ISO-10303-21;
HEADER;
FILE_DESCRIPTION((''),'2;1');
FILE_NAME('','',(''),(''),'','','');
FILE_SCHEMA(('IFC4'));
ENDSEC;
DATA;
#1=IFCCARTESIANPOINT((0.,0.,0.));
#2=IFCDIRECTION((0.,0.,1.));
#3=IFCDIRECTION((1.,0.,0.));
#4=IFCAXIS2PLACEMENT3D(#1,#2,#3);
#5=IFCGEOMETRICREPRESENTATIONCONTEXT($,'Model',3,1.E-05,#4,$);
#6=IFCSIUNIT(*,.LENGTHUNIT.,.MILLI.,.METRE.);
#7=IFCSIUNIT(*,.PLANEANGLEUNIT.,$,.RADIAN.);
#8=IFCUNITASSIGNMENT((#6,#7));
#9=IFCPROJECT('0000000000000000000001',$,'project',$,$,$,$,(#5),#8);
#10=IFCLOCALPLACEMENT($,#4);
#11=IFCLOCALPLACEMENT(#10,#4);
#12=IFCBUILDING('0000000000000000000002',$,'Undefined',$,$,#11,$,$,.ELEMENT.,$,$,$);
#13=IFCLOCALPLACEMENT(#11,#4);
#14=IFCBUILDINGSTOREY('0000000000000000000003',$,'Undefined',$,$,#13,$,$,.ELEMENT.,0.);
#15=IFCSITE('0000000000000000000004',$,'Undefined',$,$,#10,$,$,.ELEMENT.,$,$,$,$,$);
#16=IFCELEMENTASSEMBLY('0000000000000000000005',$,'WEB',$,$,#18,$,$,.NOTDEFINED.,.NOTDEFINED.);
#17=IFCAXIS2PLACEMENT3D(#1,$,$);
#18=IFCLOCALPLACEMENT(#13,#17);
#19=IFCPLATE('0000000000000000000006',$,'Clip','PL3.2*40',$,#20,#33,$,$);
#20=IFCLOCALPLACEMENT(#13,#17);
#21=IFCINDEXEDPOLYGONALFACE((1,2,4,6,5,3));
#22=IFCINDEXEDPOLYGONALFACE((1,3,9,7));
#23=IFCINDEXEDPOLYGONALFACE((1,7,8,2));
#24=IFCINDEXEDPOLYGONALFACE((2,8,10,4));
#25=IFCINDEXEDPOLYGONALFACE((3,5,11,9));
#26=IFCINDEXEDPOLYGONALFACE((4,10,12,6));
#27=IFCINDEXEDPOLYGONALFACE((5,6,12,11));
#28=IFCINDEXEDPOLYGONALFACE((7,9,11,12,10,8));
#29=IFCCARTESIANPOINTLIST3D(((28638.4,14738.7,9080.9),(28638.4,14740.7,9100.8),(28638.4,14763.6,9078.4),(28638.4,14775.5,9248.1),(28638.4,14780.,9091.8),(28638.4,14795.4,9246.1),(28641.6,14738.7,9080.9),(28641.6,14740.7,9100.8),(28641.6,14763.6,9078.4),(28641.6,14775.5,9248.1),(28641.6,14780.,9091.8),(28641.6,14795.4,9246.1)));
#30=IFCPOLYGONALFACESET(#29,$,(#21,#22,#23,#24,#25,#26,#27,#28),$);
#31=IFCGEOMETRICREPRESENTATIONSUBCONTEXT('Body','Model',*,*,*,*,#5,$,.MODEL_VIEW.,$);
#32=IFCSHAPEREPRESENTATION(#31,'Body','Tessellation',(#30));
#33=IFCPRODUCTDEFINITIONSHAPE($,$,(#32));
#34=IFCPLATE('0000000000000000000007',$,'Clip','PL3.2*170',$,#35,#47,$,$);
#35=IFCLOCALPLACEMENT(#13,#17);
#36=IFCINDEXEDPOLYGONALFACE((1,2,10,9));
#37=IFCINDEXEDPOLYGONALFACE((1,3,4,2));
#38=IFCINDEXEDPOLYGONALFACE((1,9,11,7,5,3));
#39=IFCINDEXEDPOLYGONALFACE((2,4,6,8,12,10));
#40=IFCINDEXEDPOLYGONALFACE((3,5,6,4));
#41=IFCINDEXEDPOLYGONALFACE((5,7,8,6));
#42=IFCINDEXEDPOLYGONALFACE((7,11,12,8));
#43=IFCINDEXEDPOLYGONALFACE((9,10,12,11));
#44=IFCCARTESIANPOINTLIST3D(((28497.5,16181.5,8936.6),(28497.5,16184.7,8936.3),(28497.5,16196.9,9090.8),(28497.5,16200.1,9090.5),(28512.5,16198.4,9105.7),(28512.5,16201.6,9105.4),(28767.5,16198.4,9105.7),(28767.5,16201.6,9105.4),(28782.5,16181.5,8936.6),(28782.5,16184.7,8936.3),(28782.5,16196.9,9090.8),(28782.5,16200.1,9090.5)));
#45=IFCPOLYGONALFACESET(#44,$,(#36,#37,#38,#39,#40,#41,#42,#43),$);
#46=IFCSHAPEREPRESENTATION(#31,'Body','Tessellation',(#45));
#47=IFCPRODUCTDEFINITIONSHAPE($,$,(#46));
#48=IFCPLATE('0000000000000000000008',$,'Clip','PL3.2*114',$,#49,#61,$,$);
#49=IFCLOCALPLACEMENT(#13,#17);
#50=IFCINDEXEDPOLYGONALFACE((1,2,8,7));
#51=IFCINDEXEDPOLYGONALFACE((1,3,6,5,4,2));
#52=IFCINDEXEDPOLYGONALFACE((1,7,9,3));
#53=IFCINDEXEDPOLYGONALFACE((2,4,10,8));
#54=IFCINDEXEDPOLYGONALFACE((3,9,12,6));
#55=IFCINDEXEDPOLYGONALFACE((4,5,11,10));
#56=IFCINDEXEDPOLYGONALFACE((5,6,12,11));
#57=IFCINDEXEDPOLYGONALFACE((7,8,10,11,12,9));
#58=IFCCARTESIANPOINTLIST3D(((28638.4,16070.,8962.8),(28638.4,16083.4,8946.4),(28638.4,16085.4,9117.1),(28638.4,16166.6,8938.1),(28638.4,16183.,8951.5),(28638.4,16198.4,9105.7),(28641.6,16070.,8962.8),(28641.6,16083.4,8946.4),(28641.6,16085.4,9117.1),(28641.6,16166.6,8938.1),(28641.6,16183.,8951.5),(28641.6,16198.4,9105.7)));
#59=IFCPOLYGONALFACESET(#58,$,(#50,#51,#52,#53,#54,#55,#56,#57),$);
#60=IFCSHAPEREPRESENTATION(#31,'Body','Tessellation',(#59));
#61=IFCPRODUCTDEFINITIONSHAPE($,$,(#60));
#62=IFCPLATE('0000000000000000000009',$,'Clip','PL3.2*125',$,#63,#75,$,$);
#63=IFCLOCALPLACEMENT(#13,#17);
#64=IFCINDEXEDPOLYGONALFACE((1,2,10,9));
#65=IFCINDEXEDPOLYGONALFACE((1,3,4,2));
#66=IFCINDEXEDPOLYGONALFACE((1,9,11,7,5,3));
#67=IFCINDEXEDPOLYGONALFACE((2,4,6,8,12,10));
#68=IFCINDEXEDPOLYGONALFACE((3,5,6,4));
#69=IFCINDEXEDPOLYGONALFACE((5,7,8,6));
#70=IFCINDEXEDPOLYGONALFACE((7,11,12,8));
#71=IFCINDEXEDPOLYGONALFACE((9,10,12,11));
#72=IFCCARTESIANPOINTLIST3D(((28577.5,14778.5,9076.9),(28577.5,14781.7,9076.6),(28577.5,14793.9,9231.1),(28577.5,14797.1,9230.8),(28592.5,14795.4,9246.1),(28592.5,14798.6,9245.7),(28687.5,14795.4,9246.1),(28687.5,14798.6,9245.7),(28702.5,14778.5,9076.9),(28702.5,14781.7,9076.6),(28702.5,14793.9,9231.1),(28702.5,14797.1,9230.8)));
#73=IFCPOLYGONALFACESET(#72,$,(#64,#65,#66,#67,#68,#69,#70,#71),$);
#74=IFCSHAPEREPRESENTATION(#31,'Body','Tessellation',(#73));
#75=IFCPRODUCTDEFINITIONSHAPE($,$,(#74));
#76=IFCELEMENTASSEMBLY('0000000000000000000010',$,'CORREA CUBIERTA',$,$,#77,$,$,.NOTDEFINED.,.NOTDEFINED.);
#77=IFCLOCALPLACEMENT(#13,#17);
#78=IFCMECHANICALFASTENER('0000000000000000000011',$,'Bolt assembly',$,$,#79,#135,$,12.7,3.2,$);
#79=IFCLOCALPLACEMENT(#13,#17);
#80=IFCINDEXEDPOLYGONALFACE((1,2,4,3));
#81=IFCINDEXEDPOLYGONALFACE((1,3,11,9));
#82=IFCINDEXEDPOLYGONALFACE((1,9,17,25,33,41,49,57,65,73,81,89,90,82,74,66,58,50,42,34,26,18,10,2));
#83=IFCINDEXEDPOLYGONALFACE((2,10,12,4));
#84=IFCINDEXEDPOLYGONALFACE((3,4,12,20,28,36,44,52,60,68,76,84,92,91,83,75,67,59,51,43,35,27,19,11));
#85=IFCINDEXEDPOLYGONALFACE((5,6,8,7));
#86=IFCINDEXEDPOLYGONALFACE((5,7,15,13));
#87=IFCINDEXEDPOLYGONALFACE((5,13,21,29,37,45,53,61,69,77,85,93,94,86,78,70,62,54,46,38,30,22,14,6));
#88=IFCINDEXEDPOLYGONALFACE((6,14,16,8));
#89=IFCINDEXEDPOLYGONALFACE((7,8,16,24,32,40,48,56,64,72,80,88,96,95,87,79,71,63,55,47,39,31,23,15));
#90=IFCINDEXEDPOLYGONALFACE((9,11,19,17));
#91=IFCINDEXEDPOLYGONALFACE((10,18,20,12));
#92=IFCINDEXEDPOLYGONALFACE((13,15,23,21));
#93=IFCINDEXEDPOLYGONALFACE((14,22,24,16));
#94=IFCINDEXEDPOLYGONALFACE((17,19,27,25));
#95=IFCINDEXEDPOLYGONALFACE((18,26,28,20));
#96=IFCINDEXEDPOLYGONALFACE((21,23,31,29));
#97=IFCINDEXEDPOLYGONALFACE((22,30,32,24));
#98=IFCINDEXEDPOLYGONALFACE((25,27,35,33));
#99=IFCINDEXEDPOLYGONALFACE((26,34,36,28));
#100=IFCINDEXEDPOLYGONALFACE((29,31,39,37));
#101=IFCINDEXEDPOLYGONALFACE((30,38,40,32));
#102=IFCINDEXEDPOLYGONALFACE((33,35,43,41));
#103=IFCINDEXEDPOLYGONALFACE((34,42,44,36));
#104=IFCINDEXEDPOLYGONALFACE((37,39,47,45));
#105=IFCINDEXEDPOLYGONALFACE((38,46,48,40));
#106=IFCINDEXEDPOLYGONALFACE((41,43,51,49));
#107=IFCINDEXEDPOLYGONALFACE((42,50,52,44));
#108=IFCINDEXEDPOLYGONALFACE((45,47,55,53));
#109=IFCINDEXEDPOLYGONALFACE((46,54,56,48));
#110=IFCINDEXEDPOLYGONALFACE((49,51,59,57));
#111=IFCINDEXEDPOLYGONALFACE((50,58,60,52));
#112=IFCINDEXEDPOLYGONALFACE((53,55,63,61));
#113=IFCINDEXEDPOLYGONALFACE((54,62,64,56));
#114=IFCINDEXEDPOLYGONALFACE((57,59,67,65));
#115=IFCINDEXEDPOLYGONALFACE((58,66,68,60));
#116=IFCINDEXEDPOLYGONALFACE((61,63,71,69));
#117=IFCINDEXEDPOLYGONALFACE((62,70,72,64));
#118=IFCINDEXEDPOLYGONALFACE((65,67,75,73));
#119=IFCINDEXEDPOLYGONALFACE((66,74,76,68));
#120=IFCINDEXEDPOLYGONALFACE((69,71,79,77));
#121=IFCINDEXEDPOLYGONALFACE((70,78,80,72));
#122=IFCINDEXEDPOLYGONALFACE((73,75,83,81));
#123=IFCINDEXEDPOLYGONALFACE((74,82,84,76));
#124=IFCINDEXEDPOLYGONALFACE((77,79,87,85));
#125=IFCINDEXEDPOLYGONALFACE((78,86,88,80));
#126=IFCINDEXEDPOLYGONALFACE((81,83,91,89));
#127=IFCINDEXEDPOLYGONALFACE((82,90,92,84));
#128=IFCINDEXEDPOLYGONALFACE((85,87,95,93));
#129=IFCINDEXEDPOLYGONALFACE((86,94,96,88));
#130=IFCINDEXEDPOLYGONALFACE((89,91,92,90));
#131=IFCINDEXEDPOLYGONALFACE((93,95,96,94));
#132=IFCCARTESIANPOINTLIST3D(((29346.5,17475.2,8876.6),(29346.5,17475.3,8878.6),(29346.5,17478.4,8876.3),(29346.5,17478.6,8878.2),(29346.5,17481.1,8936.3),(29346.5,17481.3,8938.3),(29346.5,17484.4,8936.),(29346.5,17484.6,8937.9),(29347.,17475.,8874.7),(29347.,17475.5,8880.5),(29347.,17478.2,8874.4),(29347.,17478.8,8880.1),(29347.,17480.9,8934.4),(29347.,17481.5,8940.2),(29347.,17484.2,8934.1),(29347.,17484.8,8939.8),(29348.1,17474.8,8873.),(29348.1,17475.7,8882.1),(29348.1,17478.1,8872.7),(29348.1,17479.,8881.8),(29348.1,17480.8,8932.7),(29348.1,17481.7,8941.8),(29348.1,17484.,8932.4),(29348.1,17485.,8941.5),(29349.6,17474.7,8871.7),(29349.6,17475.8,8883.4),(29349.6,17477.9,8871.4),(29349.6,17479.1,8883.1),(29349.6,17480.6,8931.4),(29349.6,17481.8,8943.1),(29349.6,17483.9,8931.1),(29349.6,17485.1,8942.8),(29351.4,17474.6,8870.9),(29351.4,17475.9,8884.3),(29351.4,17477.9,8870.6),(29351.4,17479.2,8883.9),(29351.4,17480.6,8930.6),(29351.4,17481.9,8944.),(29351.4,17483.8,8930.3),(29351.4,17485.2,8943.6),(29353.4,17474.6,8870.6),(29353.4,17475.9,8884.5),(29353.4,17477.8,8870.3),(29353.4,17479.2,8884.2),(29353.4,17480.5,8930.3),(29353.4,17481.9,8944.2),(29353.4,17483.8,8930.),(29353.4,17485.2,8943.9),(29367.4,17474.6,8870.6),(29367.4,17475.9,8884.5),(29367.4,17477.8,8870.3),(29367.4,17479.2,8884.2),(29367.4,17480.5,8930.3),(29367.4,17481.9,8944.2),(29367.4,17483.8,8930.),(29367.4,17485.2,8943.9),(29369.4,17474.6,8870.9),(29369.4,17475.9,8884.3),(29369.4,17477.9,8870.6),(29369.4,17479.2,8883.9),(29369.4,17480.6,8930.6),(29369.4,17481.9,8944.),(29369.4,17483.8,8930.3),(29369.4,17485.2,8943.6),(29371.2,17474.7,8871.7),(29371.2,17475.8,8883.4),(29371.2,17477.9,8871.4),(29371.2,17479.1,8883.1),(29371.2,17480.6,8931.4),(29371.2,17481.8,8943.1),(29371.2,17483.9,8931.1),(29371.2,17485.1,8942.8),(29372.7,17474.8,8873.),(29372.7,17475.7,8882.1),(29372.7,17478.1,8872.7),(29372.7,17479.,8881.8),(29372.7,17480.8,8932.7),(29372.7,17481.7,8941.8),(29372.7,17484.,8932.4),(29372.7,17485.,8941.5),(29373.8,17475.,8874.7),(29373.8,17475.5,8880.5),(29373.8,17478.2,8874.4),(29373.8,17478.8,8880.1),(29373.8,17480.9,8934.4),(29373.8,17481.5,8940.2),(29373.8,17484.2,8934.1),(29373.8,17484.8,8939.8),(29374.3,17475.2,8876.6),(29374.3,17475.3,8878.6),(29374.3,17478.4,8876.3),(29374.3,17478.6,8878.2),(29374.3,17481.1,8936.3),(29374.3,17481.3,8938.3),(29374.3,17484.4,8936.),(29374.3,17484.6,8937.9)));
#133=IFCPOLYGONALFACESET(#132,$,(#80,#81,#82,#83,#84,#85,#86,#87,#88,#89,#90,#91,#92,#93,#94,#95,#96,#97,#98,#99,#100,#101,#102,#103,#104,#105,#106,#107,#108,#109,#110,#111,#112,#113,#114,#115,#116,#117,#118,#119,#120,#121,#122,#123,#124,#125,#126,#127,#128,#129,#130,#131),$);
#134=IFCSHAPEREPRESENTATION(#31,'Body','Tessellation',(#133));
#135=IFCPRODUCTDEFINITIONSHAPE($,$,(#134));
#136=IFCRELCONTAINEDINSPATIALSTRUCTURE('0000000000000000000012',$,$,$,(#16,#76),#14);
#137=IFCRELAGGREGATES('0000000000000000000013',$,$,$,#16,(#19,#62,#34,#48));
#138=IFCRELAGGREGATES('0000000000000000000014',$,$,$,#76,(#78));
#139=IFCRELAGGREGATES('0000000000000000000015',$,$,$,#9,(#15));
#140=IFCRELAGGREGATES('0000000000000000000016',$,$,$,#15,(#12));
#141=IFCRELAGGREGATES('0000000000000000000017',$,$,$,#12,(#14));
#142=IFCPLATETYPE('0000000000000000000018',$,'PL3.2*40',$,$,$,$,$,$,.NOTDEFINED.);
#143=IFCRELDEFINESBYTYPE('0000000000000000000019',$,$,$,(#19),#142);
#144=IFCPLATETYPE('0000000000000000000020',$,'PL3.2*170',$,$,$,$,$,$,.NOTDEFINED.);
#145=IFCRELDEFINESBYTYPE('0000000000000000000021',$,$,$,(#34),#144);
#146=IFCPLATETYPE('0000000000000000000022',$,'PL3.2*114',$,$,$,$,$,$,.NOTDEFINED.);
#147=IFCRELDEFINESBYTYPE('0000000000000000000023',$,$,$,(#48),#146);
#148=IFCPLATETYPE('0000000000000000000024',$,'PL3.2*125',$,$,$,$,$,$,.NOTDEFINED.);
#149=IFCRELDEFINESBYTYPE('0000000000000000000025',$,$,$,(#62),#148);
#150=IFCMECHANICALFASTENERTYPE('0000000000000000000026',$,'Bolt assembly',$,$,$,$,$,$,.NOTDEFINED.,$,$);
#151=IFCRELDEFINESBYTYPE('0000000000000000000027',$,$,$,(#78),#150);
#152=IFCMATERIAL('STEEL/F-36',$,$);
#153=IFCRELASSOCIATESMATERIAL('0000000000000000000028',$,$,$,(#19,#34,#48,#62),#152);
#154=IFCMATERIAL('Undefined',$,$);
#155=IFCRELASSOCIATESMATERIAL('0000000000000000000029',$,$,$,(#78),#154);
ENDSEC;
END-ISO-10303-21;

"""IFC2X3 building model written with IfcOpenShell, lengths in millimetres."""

from ifc_helpers import new_model, si_unit, frame, frame_2d, origin_with_axes, place, context, subcontext, project, spatial, polyline, circle_curve, parameter, trimmed, segment, composite_curve, outline, extrude, source, transform, mapped, material, type_object, element, aggregate, save


model = new_model("IFC2X3")

# Units and contexts
model_context = context("Model", 3, precision=1e-05, world=origin_with_axes())
body_context = subcontext(model_context, "Body", "Model", "MODEL_VIEW")
ifc_project = project(units=[si_unit("LENGTHUNIT", "METRE", prefix="MILLI"), si_unit("PLANEANGLEUNIT", "RADIAN")], contexts=[model_context])

# Site, building, storey
site_placement = place(None, origin_with_axes())
site = spatial("IfcSite", under=ifc_project, at=site_placement, Name="Undefined", CompositionType="ELEMENT")
building_placement = place(site_placement, origin_with_axes())
building = spatial("IfcBuilding", under=site, at=building_placement, Name="Undefined", CompositionType="ELEMENT")
storey_placement = place(building_placement, origin_with_axes())
storey = spatial("IfcBuildingStorey", under=building, at=storey_placement, Name="Undefined", CompositionType="ELEMENT", Elevation=0.0)

# Element assembly, plates
assembly_1_placement = place(storey_placement, origin_with_axes())
assembly_1 = element("IfcElementAssembly", 1, at=assembly_1_placement, inside=storey, Name="WEB", AssemblyPlace="NOTDEFINED", PredefinedType="NOTDEFINED")
ifc_material_1 = material(Name="STEEL/F-36")
plate_type_1 = type_object("IfcPlateType", Name="PL3.2*40", PredefinedType="NOTDEFINED")
plate_1_placement = place(assembly_1_placement, frame((28640.0, 14738.7, 9080.9), z_axis=(1.0, 0.0, 0.0), x_axis=(0.0, 0.995037, -0.099504)))
plate_1 = element("IfcPlate", 2, at=plate_1_placement, type_object=plate_type_1, material=ifc_material_1, Name="Clip", Description="PL3.2*40", context=body_context, shape_type="SweptSolid", body=[
    extrude(outline(polyline([(0.0, 0.0), (25.0, 0.0), (40.0, 15.0), (40.0, 170.0), (20.0, 170.0), (0.0, 20.0), (0.0, 0.0)])), frame((0.0, 0.0, -1.6), z_axis=(0.0, 0.0, 1.0), x_axis=(1.0, 0.0, 0.0)), (0.0, 0.0, 1.0), 3.2),
])
plate_type_2 = type_object("IfcPlateType", Name="PL3.2*170", PredefinedType="NOTDEFINED")
plate_2_placement = place(assembly_1_placement, frame((28497.5, 16183.1, 8936.4), z_axis=(0.0, -0.995037, 0.099504), x_axis=(1.0, 0.0, 0.0)))
plate_2 = element("IfcPlate", 3, at=plate_2_placement, type_object=plate_type_2, material=ifc_material_1, Name="Clip", Description="PL3.2*170", context=body_context, shape_type="SweptSolid", body=[
    extrude(outline(polyline([(0.0, 0.0), (285.0, 0.0), (285.0, 155.0), (270.0, 170.0), (15.0, 170.0), (0.0, 155.0), (0.0, 0.0)])), frame((0.0, 0.0, -1.6), z_axis=(0.0, 0.0, 1.0), x_axis=(1.0, 0.0, 0.0)), (0.0, 0.0, 1.0), 3.2),
])
plate_type_3 = type_object("IfcPlateType", Name="PL3.2*114", PredefinedType="NOTDEFINED")
plate_3_placement = place(assembly_1_placement, frame((28640.0, 16198.4, 9105.7), z_axis=(1.0, 0.0, 0.0), x_axis=(0.0, -0.995037, 0.099503)))
plate_3 = element("IfcPlate", 4, at=plate_3_placement, type_object=plate_type_3, material=ifc_material_1, Name="Clip", Description="PL3.2*114", context=body_context, shape_type="SweptSolid", body=[
    extrude(outline(polyline([(0.0, 0.0), (113.6, 0.0), (113.6, 155.0), (98.6, 170.0), (15.0, 170.0), (0.0, 155.0), (0.0, 0.0)])), frame((0.0, 0.0, -1.6), z_axis=(0.0, 0.0, 1.0), x_axis=(1.0, 0.0, 0.0)), (0.0, 0.0, 1.0), 3.2),
])
plate_type_4 = type_object("IfcPlateType", Name="PL3.2*125", PredefinedType="NOTDEFINED")
plate_4_placement = place(assembly_1_placement, frame((28577.5, 14780.1, 9076.8), z_axis=(0.0, -0.995037, 0.099504), x_axis=(1.0, 0.0, 0.0)))
plate_4 = element("IfcPlate", 5, at=plate_4_placement, type_object=plate_type_4, material=ifc_material_1, Name="Clip", Description="PL3.2*125", context=body_context, shape_type="SweptSolid", body=[
    extrude(outline(polyline([(0.0, 0.0), (125.0, 0.0), (125.0, 155.0), (110.0, 170.0), (15.0, 170.0), (0.0, 155.0), (0.0, 0.0)])), frame((0.0, 0.0, -1.6), z_axis=(0.0, 0.0, 1.0), x_axis=(1.0, 0.0, 0.0)), (0.0, 0.0, 1.0), 3.2),
])

# Element assembly, mechanical fastener
ifc_material_2 = material(Name="Undefined")
mechanical_fastener_type = type_object("IfcMechanicalFastenerType", Name="Bolt assembly")
assembly_2_placement = place(storey_placement, origin_with_axes())
assembly_2 = element("IfcElementAssembly", 6, at=assembly_2_placement, inside=storey, Name="CORREA CUBIERTA", AssemblyPlace="NOTDEFINED", PredefinedType="NOTDEFINED")
shared_shape_1 = source(origin_with_axes(), body_context, "Body", "SweptSolid", [
    extrude(outline(composite_curve([segment(polyline([(7.0, 7.0), (7.0, -7.0)]), True, "CONTINUOUS"), segment(trimmed(circle_curve(frame_2d((0.0, -7.0), x_axis=(1.0, 0.0)), 7.0), [parameter(0.0)], [parameter(3.141593)], False, "PARAMETER"), True, "CONTINUOUS"), segment(polyline([(-7.0, -7.0), (-7.0, 7.0)]), True, "CONTINUOUS"), segment(trimmed(circle_curve(frame_2d((0.0, 7.0), x_axis=(-1.0, 0.0)), 7.0), [parameter(0.0)], [parameter(3.141593)], False, "PARAMETER"), True, "DISCONTINUOUS")], self_intersect=False)), frame((0.0, 0.0, 0.0), z_axis=(0.0, 1.0, 0.0), x_axis=(1.0, 0.0, 0.0)), (0.0, 0.0, 1.0), 3.3),
])
mechanical_fastener_1_placement = place(assembly_2_placement, frame((29360.4, 17481.2, 8937.3), z_axis=(1.0, 0.0, 0.0), x_axis=(0.0, -0.099503, -0.995037)))
mechanical_fastener_1 = element("IfcMechanicalFastener", 7, at=mechanical_fastener_1_placement, type_object=mechanical_fastener_type, material=ifc_material_2, Name="Bolt assembly", NominalDiameter=12.7, NominalLength=3.2, context=body_context, shape_type="MappedRepresentation", body=[
    mapped(shared_shape_1, transform((0.0, 0.0, 0.0))),
    mapped(shared_shape_1, transform((60.0, 0.0, 0.0))),
])

aggregate(assembly_1, [plate_1, plate_4, plate_2, plate_3])

aggregate(assembly_2, [mechanical_fastener_1])

save(model, "model.ifc")
